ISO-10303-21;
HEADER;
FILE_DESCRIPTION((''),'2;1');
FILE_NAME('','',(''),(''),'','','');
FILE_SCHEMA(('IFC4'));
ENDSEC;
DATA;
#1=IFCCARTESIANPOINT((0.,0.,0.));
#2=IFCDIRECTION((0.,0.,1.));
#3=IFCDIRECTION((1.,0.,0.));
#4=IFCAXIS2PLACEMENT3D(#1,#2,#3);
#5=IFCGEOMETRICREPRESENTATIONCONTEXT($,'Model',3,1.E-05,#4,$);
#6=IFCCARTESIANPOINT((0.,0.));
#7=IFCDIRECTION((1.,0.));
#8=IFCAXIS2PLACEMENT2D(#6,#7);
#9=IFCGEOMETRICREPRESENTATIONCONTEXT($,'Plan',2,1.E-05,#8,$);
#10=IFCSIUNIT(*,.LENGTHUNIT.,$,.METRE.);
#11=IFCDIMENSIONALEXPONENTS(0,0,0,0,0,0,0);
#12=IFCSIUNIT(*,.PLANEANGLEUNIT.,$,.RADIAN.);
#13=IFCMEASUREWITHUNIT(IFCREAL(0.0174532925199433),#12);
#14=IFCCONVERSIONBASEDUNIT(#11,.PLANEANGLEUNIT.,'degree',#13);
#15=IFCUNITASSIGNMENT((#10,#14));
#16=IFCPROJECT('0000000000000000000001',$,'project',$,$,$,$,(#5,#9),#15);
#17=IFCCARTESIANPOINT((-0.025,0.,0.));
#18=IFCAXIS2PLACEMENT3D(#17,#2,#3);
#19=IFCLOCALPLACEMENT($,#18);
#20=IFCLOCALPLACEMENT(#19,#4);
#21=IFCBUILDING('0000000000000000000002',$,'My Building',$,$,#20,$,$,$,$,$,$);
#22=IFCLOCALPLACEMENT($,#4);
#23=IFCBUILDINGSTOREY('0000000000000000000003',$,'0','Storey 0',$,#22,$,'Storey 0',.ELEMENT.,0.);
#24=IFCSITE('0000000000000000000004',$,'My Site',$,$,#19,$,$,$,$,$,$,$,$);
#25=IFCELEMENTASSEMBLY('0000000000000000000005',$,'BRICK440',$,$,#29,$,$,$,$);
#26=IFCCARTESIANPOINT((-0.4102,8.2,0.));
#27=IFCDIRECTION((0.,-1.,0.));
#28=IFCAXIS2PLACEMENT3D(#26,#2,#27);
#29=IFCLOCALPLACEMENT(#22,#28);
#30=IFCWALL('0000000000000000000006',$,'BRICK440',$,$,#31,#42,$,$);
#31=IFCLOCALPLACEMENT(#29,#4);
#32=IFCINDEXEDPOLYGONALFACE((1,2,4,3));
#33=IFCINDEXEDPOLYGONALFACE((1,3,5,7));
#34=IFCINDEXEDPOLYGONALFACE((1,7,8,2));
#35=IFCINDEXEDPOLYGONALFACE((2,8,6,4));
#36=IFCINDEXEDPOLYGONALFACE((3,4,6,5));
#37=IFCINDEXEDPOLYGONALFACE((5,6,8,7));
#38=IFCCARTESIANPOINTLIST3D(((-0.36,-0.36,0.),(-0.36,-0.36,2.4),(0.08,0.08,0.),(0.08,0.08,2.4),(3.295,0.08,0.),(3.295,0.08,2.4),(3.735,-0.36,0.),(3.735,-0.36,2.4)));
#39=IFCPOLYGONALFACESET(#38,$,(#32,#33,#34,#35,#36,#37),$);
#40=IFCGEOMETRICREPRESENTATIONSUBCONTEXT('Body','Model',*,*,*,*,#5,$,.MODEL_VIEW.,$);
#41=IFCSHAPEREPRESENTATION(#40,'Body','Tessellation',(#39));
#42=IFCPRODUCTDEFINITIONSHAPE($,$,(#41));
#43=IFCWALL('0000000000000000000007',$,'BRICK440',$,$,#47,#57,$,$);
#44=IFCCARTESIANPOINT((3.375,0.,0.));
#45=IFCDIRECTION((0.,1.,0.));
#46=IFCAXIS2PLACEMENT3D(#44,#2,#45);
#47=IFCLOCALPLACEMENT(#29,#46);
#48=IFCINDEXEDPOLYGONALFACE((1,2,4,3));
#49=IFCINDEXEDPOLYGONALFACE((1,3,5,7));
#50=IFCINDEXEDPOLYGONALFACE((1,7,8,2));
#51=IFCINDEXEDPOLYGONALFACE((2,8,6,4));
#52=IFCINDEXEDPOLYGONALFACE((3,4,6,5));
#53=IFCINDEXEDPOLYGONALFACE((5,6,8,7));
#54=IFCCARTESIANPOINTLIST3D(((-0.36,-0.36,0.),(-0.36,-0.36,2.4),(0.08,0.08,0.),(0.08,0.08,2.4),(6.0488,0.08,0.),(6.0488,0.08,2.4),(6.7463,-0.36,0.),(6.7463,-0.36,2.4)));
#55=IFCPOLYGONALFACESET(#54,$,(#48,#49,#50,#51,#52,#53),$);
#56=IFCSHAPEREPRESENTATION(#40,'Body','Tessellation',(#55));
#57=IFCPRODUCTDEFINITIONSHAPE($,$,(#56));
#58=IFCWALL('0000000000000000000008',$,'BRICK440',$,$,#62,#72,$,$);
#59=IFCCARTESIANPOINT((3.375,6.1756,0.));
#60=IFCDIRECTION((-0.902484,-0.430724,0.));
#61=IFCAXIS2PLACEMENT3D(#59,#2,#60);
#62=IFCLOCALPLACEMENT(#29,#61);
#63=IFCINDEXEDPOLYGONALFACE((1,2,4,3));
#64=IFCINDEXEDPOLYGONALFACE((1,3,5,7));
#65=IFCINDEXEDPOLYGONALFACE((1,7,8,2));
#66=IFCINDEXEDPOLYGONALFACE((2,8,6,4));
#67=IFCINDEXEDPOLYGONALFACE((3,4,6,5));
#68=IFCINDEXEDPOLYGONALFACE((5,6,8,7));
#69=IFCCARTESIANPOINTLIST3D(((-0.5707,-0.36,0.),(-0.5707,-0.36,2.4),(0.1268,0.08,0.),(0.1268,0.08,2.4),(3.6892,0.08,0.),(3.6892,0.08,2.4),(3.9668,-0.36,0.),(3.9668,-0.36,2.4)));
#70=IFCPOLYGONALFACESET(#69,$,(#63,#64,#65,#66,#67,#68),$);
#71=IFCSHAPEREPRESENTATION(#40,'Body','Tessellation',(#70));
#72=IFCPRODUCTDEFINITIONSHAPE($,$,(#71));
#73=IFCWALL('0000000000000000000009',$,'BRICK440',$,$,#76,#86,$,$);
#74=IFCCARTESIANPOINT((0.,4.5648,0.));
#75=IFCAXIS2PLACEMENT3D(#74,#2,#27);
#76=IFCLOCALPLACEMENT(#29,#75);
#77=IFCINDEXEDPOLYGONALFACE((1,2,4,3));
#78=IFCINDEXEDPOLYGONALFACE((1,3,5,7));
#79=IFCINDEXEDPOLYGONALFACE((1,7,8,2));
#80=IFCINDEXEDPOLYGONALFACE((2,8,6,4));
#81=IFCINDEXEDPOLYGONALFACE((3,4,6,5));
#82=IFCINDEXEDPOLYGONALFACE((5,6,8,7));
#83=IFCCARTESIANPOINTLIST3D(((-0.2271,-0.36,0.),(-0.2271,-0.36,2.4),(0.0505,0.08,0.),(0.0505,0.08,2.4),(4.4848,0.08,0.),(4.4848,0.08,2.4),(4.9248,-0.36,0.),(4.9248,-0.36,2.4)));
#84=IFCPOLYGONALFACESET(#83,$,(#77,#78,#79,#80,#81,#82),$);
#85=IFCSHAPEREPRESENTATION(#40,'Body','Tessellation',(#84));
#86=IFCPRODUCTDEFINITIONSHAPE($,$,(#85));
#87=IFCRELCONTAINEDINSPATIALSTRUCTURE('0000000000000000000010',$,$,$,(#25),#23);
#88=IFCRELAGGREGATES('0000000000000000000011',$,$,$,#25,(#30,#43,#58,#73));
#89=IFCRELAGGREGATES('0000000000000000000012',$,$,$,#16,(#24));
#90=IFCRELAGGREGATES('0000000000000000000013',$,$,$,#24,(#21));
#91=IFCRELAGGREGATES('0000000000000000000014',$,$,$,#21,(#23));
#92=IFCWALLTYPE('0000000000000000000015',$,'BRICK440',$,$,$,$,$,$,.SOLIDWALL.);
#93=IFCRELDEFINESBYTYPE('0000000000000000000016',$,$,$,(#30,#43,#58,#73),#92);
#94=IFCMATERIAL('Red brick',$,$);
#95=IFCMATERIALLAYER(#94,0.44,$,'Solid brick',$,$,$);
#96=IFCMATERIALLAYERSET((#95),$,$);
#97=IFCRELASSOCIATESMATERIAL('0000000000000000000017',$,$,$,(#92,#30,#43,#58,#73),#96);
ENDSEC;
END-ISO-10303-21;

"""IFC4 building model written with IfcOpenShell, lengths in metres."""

from ifc_helpers import new_model, entity, si_unit, converted_unit, frame, origin, origin_with_axes, origin_2d_with_axis, place, context, subcontext, project, spatial, polyline, outline, extrude, material, layer, layer_set, layer_usage, type_object, element, aggregate, save


model = new_model("IFC4")

# Units and contexts
model_context = context("Model", 3, precision=1e-05, world=origin_with_axes())
plan_context = context("Plan", 2, precision=1e-05, world=origin_2d_with_axis())
body_context = subcontext(model_context, "Body", "Model", "MODEL_VIEW")
ifc_project = project(units=[si_unit("LENGTHUNIT", "METRE"), converted_unit("PLANEANGLEUNIT", "degree", entity("IfcReal", 0.0174532925199433), si_unit("PLANEANGLEUNIT", "RADIAN"), dimensions=[0, 0, 0, 0, 0, 0, 0])], contexts=[model_context, plan_context])

# Site, building, storey
site_placement = place(None, frame((-0.025, 0.0, 0.0), z_axis=(0.0, 0.0, 1.0), x_axis=(1.0, 0.0, 0.0)))
site = spatial("IfcSite", under=ifc_project, at=site_placement, Name="My Site")
building_placement = place(site_placement, origin_with_axes())
building = spatial("IfcBuilding", under=site, at=building_placement, Name="My Building")
storey_placement = place(None, origin_with_axes())
storey = spatial("IfcBuildingStorey", under=building, at=storey_placement, Name="0", Description="Storey 0", LongName="Storey 0", CompositionType="ELEMENT", Elevation=0.0)

# Element assembly, walls
assembly_1_placement = place(storey_placement, frame((-0.4102, 8.2, 0.0), z_axis=(0.0, 0.0, 1.0), x_axis=(0.0, -1.0, 0.0)))
assembly_1 = element("IfcElementAssembly", 1, at=assembly_1_placement, inside=storey, Name="BRICK440")
ifc_material_1 = material(Name="Red brick")
ifc_layer_1 = layer(ifc_material_1, 0.44, Name="Solid brick")
ifc_layer_set_1 = layer_set([ifc_layer_1])
ifc_layer_usage_1 = layer_usage(ifc_layer_set_1, "AXIS2", "POSITIVE", -0.36)
wall_type = type_object("IfcWallType", Name="BRICK440", PredefinedType="SOLIDWALL", material=ifc_layer_set_1)
wall_1_placement = place(assembly_1_placement, origin_with_axes())
wall_1 = element("IfcWall", 2, at=wall_1_placement, type_object=wall_type, material=ifc_layer_usage_1, Name="BRICK440", context=body_context, shape_type="SweptSolid", body=[
    extrude(outline(polyline([(0.08, 0.08), (-0.36, -0.36), (3.735, -0.36), (3.295, 0.08), (0.08, 0.08)])), origin(), (0.0, 0.0, 1.0), 2.4),
])
ifc_layer_usage_2 = layer_usage(ifc_layer_set_1, "AXIS2", "POSITIVE", -0.36)
wall_2_placement = place(assembly_1_placement, frame((3.375, 0.0, 0.0), z_axis=(0.0, 0.0, 1.0), x_axis=(0.0, 1.0, 0.0)))
wall_2 = element("IfcWall", 3, at=wall_2_placement, type_object=wall_type, material=ifc_layer_usage_2, Name="BRICK440", context=body_context, shape_type="SweptSolid", body=[
    extrude(outline(polyline([(0.08, 0.08), (-0.36, -0.36), (6.7463, -0.36), (6.0488, 0.08), (0.08, 0.08)])), origin(), (0.0, 0.0, 1.0), 2.4),
])
ifc_layer_usage_3 = layer_usage(ifc_layer_set_1, "AXIS2", "POSITIVE", -0.36)
wall_3_placement = place(assembly_1_placement, frame((3.375, 6.1756, 0.0), z_axis=(0.0, 0.0, 1.0), x_axis=(-0.902484, -0.430724, 0.0)))
wall_3 = element("IfcWall", 4, at=wall_3_placement, type_object=wall_type, material=ifc_layer_usage_3, Name="BRICK440", context=body_context, shape_type="SweptSolid", body=[
    extrude(outline(polyline([(0.1268, 0.08), (-0.5707, -0.36), (3.9668, -0.36), (3.6892, 0.08), (0.1268, 0.08)])), origin(), (0.0, 0.0, 1.0), 2.4),
])
ifc_layer_usage_4 = layer_usage(ifc_layer_set_1, "AXIS2", "POSITIVE", -0.36)
wall_4_placement = place(assembly_1_placement, frame((0.0, 4.5648, 0.0), z_axis=(0.0, 0.0, 1.0), x_axis=(0.0, -1.0, 0.0)))
wall_4 = element("IfcWall", 5, at=wall_4_placement, type_object=wall_type, material=ifc_layer_usage_4, Name="BRICK440", context=body_context, shape_type="SweptSolid", body=[
    extrude(outline(polyline([(0.0505, 0.08), (-0.2271, -0.36), (4.9248, -0.36), (4.4848, 0.08), (0.0505, 0.08)])), origin(), (0.0, 0.0, 1.0), 2.4),
])
aggregate(assembly_1, [wall_1, wall_2, wall_3, wall_4])

save(model, "model.ifc")
